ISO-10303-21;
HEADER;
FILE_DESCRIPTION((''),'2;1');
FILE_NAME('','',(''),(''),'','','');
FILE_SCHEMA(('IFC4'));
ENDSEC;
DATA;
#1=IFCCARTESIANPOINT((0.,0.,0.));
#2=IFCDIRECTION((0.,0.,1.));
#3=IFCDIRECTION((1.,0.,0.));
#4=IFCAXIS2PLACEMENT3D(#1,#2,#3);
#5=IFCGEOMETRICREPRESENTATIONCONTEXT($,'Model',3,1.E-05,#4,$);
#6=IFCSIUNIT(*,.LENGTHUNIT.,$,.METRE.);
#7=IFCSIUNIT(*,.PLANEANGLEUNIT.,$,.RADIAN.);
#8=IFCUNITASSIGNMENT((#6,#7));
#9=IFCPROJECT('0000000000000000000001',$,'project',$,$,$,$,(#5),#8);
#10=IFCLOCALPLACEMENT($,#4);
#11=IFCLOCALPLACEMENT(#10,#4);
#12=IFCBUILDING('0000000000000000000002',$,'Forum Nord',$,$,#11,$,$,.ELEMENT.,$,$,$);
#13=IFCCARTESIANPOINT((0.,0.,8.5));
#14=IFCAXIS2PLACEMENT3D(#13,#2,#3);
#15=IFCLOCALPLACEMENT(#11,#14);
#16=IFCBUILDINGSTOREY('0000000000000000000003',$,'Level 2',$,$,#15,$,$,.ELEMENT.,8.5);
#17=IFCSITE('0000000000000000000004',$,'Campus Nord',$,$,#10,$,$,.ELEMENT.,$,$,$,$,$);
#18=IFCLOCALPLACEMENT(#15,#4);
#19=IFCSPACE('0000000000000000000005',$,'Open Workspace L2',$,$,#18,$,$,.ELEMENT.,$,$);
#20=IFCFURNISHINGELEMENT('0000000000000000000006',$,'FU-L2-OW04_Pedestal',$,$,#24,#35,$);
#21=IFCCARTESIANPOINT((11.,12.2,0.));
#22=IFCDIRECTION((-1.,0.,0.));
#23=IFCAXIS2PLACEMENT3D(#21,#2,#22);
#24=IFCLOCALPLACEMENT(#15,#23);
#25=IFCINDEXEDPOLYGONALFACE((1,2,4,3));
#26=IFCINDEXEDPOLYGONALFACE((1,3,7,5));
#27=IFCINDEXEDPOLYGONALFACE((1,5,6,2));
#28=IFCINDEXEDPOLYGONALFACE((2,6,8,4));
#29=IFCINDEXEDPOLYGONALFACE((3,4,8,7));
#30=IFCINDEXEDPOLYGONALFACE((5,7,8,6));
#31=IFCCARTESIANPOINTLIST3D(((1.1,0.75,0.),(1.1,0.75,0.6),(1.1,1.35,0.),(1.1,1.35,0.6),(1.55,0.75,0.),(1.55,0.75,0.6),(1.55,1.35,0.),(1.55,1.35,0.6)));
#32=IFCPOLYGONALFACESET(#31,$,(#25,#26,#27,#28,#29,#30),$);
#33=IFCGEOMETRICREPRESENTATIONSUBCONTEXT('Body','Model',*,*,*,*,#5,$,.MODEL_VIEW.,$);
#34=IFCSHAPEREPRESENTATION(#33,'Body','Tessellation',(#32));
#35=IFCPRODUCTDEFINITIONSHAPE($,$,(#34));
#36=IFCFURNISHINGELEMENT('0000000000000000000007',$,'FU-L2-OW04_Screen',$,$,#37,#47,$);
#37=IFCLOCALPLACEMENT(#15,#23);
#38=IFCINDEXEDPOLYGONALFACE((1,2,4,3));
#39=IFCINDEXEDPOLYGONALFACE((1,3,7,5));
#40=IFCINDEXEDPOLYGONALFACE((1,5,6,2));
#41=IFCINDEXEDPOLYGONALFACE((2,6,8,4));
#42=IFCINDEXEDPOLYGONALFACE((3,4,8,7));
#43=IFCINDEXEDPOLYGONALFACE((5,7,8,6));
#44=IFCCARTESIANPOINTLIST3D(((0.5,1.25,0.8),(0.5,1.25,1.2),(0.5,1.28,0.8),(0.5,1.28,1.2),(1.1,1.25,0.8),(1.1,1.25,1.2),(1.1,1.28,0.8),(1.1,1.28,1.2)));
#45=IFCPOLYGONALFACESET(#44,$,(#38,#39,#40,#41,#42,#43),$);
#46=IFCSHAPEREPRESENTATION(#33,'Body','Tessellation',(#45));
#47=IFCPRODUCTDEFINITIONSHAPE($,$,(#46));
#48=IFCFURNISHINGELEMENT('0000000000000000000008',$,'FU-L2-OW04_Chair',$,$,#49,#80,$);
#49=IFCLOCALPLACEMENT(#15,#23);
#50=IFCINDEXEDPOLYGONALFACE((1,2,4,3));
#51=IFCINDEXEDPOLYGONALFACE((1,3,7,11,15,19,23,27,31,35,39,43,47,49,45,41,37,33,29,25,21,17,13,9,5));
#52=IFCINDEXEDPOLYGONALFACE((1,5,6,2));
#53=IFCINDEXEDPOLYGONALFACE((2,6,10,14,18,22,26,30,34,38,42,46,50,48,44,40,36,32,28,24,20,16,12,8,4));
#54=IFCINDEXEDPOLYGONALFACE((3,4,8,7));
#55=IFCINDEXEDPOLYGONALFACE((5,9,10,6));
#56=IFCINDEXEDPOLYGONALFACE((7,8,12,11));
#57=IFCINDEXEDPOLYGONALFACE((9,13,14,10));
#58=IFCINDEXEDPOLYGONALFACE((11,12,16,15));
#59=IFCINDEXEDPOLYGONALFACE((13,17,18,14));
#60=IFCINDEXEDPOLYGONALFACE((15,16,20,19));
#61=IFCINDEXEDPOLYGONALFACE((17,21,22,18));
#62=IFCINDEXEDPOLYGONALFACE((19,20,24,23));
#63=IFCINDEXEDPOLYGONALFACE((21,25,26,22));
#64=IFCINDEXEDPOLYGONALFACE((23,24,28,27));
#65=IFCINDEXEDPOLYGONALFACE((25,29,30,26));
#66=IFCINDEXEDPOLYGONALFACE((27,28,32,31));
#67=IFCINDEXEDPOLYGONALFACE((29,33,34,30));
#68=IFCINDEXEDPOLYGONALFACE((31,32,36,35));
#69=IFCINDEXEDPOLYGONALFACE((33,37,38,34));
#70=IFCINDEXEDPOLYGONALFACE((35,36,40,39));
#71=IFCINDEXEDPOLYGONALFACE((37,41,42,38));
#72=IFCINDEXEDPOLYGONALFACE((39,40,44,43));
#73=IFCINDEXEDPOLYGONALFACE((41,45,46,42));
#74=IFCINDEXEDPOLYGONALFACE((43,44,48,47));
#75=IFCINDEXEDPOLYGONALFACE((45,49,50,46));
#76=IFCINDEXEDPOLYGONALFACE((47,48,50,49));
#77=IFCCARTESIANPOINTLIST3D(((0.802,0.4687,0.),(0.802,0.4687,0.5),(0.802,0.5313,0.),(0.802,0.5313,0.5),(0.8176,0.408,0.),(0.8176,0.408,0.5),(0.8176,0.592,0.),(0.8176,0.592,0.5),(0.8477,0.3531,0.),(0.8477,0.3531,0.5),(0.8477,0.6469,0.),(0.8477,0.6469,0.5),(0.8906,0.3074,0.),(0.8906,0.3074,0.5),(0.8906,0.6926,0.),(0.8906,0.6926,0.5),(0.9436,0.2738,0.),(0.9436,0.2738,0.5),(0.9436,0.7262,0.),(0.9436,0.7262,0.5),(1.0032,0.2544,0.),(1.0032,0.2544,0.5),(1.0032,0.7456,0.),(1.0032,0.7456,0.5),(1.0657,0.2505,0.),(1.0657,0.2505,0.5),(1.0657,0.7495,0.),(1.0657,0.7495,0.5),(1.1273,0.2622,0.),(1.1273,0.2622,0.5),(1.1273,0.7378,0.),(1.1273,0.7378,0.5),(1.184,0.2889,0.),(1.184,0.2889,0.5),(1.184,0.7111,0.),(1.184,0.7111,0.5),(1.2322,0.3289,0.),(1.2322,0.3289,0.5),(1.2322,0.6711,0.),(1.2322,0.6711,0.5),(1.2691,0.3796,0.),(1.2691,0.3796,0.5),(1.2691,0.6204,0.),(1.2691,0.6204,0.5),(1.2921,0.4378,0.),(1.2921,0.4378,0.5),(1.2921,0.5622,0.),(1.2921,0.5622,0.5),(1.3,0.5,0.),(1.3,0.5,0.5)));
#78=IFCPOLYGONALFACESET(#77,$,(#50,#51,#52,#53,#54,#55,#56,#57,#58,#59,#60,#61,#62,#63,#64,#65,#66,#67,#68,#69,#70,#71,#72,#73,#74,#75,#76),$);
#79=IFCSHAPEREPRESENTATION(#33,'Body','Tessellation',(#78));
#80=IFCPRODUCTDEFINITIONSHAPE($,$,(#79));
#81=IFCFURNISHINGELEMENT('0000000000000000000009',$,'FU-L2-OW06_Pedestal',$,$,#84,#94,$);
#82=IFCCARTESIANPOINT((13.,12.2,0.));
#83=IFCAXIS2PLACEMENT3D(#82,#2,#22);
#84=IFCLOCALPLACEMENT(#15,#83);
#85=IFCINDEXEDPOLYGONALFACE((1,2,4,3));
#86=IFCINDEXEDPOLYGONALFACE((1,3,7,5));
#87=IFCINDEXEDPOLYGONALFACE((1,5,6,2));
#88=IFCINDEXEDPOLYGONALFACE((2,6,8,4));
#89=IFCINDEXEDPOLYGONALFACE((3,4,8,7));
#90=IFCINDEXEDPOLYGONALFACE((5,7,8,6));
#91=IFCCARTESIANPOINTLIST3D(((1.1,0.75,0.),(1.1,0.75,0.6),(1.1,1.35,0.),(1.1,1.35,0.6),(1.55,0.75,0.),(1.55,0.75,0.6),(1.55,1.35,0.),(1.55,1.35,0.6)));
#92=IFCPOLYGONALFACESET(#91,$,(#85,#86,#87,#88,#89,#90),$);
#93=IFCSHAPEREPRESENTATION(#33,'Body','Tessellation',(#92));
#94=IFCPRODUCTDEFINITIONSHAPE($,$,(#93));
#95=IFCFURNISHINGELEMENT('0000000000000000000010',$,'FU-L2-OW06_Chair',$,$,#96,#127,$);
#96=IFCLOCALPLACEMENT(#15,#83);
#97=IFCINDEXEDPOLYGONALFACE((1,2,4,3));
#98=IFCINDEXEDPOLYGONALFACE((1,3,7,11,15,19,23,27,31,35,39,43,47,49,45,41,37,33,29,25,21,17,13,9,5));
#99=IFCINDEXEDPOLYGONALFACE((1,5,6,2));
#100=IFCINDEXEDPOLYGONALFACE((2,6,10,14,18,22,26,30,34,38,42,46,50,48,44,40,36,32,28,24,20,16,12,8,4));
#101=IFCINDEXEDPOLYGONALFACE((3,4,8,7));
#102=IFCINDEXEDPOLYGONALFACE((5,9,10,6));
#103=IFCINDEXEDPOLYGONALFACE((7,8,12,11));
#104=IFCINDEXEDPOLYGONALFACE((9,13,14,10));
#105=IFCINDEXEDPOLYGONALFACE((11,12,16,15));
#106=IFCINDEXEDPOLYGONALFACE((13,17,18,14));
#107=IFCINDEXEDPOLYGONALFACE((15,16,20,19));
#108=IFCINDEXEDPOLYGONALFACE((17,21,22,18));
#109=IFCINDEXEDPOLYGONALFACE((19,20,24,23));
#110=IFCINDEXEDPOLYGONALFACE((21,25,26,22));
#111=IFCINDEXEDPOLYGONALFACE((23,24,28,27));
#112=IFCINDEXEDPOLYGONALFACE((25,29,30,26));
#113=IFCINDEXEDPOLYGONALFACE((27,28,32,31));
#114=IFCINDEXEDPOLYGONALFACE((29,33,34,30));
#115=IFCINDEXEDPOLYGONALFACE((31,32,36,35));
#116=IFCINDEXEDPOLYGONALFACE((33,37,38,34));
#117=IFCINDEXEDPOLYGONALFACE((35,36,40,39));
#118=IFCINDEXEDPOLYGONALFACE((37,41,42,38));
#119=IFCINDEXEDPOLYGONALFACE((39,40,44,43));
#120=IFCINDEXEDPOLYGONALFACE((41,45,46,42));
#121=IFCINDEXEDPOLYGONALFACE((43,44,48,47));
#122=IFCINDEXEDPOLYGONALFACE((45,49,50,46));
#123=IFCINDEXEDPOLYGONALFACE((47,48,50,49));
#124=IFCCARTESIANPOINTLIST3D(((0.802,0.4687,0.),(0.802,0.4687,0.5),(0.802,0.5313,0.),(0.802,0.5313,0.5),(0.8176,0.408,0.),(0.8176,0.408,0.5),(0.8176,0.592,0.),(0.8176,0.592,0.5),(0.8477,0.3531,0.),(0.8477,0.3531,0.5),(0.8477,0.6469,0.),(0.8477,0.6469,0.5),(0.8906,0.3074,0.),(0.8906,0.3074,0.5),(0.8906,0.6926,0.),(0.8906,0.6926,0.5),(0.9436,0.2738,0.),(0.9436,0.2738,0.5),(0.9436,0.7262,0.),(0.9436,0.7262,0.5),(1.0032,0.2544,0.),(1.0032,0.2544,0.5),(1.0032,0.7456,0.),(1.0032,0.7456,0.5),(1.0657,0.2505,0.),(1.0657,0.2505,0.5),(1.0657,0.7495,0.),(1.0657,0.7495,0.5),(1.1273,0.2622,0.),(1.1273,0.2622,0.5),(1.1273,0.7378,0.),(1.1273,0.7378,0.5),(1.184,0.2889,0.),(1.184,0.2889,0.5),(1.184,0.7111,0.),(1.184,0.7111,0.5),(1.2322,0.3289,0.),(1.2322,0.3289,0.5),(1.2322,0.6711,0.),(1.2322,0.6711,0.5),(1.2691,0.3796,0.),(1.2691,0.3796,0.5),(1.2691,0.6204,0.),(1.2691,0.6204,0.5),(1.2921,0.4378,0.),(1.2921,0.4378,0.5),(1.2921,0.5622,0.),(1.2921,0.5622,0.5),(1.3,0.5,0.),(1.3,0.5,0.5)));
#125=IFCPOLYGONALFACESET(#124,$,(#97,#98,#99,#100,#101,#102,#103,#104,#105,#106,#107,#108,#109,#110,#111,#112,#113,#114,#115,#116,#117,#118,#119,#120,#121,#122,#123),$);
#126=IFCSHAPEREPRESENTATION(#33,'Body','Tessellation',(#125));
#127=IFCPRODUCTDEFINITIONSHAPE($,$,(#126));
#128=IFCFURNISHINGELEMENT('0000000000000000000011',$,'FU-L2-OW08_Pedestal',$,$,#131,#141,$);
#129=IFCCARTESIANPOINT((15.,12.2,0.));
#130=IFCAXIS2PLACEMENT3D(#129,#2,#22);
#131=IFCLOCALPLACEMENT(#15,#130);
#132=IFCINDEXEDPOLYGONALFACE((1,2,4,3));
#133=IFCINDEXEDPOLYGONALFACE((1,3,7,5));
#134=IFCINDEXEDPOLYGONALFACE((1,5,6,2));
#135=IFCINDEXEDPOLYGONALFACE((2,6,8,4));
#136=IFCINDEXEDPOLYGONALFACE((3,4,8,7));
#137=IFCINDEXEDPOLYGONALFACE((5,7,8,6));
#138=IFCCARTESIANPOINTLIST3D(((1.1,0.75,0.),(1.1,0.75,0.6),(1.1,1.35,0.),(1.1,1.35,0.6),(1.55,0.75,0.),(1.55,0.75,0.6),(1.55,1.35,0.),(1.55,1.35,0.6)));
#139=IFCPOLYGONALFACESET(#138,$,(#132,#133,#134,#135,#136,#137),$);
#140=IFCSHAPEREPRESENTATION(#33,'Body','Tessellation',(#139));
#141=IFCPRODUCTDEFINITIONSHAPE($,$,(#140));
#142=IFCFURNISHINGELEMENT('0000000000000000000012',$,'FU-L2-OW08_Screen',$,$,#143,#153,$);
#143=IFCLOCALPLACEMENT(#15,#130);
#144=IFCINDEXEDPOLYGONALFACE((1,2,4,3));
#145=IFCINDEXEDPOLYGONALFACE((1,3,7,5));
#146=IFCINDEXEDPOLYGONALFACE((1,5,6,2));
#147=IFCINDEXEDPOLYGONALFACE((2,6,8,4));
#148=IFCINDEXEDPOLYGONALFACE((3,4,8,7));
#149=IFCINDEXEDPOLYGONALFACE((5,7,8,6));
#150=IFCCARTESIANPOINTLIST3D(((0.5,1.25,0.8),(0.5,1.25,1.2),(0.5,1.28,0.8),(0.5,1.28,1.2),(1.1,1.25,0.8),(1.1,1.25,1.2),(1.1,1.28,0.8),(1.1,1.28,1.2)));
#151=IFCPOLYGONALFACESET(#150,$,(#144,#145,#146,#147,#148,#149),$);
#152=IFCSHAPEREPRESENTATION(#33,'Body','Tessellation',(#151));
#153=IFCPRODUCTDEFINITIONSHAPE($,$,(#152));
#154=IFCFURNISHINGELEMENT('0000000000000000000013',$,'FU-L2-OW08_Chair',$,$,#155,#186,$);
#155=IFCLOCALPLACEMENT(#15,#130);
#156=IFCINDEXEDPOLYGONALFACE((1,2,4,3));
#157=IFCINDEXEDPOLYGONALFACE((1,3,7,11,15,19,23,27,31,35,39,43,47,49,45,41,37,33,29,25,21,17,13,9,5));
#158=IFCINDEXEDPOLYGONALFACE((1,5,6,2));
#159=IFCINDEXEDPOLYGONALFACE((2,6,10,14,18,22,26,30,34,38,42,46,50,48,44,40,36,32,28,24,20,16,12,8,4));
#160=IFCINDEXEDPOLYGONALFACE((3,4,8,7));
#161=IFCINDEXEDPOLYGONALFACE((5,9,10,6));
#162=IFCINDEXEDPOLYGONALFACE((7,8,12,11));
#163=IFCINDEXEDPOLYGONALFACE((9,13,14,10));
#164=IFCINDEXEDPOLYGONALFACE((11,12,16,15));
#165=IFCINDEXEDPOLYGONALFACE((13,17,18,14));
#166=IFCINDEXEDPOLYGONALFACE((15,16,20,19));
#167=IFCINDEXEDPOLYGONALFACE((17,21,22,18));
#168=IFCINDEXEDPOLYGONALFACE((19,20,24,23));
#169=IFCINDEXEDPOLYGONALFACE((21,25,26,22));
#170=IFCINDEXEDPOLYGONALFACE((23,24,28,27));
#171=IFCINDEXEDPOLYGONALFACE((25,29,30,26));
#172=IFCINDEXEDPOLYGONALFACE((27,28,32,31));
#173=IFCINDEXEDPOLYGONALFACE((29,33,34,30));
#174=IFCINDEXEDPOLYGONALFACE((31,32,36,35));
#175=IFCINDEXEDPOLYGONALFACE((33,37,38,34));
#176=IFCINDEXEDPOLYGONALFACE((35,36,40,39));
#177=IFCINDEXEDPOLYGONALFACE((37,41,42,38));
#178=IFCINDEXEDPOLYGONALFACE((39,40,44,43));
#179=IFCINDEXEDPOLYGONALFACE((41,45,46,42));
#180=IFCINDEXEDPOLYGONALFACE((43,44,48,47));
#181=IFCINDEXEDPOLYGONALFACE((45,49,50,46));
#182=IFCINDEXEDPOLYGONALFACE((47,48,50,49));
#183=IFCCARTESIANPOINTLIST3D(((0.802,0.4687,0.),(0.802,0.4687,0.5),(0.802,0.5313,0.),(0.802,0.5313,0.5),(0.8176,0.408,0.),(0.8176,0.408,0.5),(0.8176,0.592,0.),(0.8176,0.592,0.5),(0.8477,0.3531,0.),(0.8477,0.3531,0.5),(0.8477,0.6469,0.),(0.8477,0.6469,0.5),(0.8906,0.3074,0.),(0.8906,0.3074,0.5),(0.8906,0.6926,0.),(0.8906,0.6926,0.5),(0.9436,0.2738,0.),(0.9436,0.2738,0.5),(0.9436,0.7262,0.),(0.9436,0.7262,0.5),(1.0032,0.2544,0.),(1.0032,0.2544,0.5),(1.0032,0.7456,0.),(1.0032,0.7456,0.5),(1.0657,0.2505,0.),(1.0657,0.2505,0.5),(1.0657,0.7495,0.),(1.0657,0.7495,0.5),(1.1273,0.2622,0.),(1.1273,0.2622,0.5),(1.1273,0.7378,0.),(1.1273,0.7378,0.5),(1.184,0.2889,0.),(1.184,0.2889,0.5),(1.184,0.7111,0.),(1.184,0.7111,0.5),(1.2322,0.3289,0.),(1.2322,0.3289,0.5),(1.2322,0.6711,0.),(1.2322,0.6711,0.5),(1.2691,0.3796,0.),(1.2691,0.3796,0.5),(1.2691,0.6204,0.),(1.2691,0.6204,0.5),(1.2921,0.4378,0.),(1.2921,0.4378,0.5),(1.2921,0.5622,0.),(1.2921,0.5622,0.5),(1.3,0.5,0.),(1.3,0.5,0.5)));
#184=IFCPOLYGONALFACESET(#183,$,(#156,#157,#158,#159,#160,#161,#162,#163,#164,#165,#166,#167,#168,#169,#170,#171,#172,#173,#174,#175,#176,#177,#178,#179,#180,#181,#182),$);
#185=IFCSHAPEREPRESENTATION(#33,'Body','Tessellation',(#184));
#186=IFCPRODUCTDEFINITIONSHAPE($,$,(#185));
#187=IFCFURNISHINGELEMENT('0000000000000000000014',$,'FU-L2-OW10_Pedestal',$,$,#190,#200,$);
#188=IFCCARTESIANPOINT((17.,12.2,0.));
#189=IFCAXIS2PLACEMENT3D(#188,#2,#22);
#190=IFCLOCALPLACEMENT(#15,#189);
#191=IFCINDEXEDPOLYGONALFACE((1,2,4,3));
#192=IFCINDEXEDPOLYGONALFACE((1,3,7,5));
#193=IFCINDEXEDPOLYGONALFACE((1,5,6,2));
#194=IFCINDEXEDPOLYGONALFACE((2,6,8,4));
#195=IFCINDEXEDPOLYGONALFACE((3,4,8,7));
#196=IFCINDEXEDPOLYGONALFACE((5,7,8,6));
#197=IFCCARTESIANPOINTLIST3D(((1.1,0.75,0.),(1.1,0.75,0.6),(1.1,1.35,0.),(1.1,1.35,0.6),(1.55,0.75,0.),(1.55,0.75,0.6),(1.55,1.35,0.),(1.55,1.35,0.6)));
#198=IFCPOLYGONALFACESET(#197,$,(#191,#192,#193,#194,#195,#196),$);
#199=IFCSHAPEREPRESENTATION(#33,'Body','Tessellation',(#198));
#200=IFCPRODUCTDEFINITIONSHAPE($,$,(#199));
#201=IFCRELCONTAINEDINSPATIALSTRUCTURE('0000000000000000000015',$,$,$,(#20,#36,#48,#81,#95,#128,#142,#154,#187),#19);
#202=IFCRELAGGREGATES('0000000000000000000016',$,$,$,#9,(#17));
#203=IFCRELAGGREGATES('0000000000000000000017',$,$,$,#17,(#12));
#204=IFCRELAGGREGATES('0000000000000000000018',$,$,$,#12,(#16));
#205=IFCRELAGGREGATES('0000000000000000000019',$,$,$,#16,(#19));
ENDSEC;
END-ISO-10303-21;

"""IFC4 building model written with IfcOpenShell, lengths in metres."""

from ifc_helpers import new_model, si_unit, frame, frame_2d, origin_with_axes, place, context, subcontext, project, spatial, rectangle, circle, extrude, element, save


model = new_model("IFC4")

# Units and contexts
model_context = context("Model", 3, precision=1e-05, world=origin_with_axes())
body_context = subcontext(model_context, "Body", "Model", "MODEL_VIEW")
ifc_project = project(units=[si_unit("LENGTHUNIT", "METRE"), si_unit("PLANEANGLEUNIT", "RADIAN")], contexts=[model_context])

# Site, building, storey, space
site_placement = place(None, origin_with_axes())
site = spatial("IfcSite", under=ifc_project, at=site_placement, Name="Campus Nord", CompositionType="ELEMENT")
building_placement = place(site_placement, origin_with_axes())
building = spatial("IfcBuilding", under=site, at=building_placement, Name="Forum Nord", CompositionType="ELEMENT")
storey_placement = place(building_placement, frame((0.0, 0.0, 8.5), z_axis=(0.0, 0.0, 1.0), x_axis=(1.0, 0.0, 0.0)))
storey = spatial("IfcBuildingStorey", under=building, at=storey_placement, Name="Level 2", CompositionType="ELEMENT", Elevation=8.5)
space_placement = place(storey_placement, origin_with_axes())
space = spatial("IfcSpace", under=storey, at=space_placement, Name="Open Workspace L2", CompositionType="ELEMENT")

# Furnishing elements
furnishing_1_placement = place(storey_placement, frame((11.0, 12.2, 0.0), z_axis=(0.0, 0.0, 1.0), x_axis=(-1.0, 0.0, 0.0)))
element("IfcFurnishingElement", 1, at=furnishing_1_placement, inside=space, Name="FU-L2-OW04_Pedestal", context=body_context, shape_type="SweptSolid", body=[
    extrude(rectangle(XDim=0.45, YDim=0.6, at=frame_2d((1.325, 1.05), x_axis=(1.0, 0.0))), origin_with_axes(), (0.0, 0.0, 1.0), 0.6),
])
furnishing_2_placement = place(storey_placement, frame((11.0, 12.2, 0.0), z_axis=(0.0, 0.0, 1.0), x_axis=(-1.0, 0.0, 0.0)))
element("IfcFurnishingElement", 2, at=furnishing_2_placement, inside=space, Name="FU-L2-OW04_Screen", context=body_context, shape_type="SweptSolid", body=[
    extrude(rectangle(XDim=0.6, YDim=0.03, at=frame_2d((0.8, 1.265), x_axis=(1.0, 0.0))), frame((0.0, 0.0, 0.8), z_axis=(0.0, 0.0, 1.0), x_axis=(1.0, 0.0, 0.0)), (0.0, 0.0, 1.0), 0.4),
])
furnishing_3_placement = place(storey_placement, frame((11.0, 12.2, 0.0), z_axis=(0.0, 0.0, 1.0), x_axis=(-1.0, 0.0, 0.0)))
element("IfcFurnishingElement", 3, at=furnishing_3_placement, inside=space, Name="FU-L2-OW04_Chair", context=body_context, shape_type="SweptSolid", body=[
    extrude(circle(Radius=0.25, at=frame_2d((1.05, 0.5), x_axis=(1.0, 0.0))), origin_with_axes(), (0.0, 0.0, 1.0), 0.5),
])
furnishing_4_placement = place(storey_placement, frame((13.0, 12.2, 0.0), z_axis=(0.0, 0.0, 1.0), x_axis=(-1.0, 0.0, 0.0)))
element("IfcFurnishingElement", 4, at=furnishing_4_placement, inside=space, Name="FU-L2-OW06_Pedestal", context=body_context, shape_type="SweptSolid", body=[
    extrude(rectangle(XDim=0.45, YDim=0.6, at=frame_2d((1.325, 1.05), x_axis=(1.0, 0.0))), origin_with_axes(), (0.0, 0.0, 1.0), 0.6),
])
furnishing_5_placement = place(storey_placement, frame((13.0, 12.2, 0.0), z_axis=(0.0, 0.0, 1.0), x_axis=(-1.0, 0.0, 0.0)))
element("IfcFurnishingElement", 5, at=furnishing_5_placement, inside=space, Name="FU-L2-OW06_Chair", context=body_context, shape_type="SweptSolid", body=[
    extrude(circle(Radius=0.25, at=frame_2d((1.05, 0.5), x_axis=(1.0, 0.0))), origin_with_axes(), (0.0, 0.0, 1.0), 0.5),
])
furnishing_6_placement = place(storey_placement, frame((15.0, 12.2, 0.0), z_axis=(0.0, 0.0, 1.0), x_axis=(-1.0, 0.0, 0.0)))
element("IfcFurnishingElement", 6, at=furnishing_6_placement, inside=space, Name="FU-L2-OW08_Pedestal", context=body_context, shape_type="SweptSolid", body=[
    extrude(rectangle(XDim=0.45, YDim=0.6, at=frame_2d((1.325, 1.05), x_axis=(1.0, 0.0))), origin_with_axes(), (0.0, 0.0, 1.0), 0.6),
])
furnishing_7_placement = place(storey_placement, frame((15.0, 12.2, 0.0), z_axis=(0.0, 0.0, 1.0), x_axis=(-1.0, 0.0, 0.0)))
element("IfcFurnishingElement", 7, at=furnishing_7_placement, inside=space, Name="FU-L2-OW08_Screen", context=body_context, shape_type="SweptSolid", body=[
    extrude(rectangle(XDim=0.6, YDim=0.03, at=frame_2d((0.8, 1.265), x_axis=(1.0, 0.0))), frame((0.0, 0.0, 0.8), z_axis=(0.0, 0.0, 1.0), x_axis=(1.0, 0.0, 0.0)), (0.0, 0.0, 1.0), 0.4),
])
furnishing_8_placement = place(storey_placement, frame((15.0, 12.2, 0.0), z_axis=(0.0, 0.0, 1.0), x_axis=(-1.0, 0.0, 0.0)))
element("IfcFurnishingElement", 8, at=furnishing_8_placement, inside=space, Name="FU-L2-OW08_Chair", context=body_context, shape_type="SweptSolid", body=[
    extrude(circle(Radius=0.25, at=frame_2d((1.05, 0.5), x_axis=(1.0, 0.0))), origin_with_axes(), (0.0, 0.0, 1.0), 0.5),
])
furnishing_9_placement = place(storey_placement, frame((17.0, 12.2, 0.0), z_axis=(0.0, 0.0, 1.0), x_axis=(-1.0, 0.0, 0.0)))
element("IfcFurnishingElement", 9, at=furnishing_9_placement, inside=space, Name="FU-L2-OW10_Pedestal", context=body_context, shape_type="SweptSolid", body=[
    extrude(rectangle(XDim=0.45, YDim=0.6, at=frame_2d((1.325, 1.05), x_axis=(1.0, 0.0))), origin_with_axes(), (0.0, 0.0, 1.0), 0.6),
])

save(model, "model.ifc")
